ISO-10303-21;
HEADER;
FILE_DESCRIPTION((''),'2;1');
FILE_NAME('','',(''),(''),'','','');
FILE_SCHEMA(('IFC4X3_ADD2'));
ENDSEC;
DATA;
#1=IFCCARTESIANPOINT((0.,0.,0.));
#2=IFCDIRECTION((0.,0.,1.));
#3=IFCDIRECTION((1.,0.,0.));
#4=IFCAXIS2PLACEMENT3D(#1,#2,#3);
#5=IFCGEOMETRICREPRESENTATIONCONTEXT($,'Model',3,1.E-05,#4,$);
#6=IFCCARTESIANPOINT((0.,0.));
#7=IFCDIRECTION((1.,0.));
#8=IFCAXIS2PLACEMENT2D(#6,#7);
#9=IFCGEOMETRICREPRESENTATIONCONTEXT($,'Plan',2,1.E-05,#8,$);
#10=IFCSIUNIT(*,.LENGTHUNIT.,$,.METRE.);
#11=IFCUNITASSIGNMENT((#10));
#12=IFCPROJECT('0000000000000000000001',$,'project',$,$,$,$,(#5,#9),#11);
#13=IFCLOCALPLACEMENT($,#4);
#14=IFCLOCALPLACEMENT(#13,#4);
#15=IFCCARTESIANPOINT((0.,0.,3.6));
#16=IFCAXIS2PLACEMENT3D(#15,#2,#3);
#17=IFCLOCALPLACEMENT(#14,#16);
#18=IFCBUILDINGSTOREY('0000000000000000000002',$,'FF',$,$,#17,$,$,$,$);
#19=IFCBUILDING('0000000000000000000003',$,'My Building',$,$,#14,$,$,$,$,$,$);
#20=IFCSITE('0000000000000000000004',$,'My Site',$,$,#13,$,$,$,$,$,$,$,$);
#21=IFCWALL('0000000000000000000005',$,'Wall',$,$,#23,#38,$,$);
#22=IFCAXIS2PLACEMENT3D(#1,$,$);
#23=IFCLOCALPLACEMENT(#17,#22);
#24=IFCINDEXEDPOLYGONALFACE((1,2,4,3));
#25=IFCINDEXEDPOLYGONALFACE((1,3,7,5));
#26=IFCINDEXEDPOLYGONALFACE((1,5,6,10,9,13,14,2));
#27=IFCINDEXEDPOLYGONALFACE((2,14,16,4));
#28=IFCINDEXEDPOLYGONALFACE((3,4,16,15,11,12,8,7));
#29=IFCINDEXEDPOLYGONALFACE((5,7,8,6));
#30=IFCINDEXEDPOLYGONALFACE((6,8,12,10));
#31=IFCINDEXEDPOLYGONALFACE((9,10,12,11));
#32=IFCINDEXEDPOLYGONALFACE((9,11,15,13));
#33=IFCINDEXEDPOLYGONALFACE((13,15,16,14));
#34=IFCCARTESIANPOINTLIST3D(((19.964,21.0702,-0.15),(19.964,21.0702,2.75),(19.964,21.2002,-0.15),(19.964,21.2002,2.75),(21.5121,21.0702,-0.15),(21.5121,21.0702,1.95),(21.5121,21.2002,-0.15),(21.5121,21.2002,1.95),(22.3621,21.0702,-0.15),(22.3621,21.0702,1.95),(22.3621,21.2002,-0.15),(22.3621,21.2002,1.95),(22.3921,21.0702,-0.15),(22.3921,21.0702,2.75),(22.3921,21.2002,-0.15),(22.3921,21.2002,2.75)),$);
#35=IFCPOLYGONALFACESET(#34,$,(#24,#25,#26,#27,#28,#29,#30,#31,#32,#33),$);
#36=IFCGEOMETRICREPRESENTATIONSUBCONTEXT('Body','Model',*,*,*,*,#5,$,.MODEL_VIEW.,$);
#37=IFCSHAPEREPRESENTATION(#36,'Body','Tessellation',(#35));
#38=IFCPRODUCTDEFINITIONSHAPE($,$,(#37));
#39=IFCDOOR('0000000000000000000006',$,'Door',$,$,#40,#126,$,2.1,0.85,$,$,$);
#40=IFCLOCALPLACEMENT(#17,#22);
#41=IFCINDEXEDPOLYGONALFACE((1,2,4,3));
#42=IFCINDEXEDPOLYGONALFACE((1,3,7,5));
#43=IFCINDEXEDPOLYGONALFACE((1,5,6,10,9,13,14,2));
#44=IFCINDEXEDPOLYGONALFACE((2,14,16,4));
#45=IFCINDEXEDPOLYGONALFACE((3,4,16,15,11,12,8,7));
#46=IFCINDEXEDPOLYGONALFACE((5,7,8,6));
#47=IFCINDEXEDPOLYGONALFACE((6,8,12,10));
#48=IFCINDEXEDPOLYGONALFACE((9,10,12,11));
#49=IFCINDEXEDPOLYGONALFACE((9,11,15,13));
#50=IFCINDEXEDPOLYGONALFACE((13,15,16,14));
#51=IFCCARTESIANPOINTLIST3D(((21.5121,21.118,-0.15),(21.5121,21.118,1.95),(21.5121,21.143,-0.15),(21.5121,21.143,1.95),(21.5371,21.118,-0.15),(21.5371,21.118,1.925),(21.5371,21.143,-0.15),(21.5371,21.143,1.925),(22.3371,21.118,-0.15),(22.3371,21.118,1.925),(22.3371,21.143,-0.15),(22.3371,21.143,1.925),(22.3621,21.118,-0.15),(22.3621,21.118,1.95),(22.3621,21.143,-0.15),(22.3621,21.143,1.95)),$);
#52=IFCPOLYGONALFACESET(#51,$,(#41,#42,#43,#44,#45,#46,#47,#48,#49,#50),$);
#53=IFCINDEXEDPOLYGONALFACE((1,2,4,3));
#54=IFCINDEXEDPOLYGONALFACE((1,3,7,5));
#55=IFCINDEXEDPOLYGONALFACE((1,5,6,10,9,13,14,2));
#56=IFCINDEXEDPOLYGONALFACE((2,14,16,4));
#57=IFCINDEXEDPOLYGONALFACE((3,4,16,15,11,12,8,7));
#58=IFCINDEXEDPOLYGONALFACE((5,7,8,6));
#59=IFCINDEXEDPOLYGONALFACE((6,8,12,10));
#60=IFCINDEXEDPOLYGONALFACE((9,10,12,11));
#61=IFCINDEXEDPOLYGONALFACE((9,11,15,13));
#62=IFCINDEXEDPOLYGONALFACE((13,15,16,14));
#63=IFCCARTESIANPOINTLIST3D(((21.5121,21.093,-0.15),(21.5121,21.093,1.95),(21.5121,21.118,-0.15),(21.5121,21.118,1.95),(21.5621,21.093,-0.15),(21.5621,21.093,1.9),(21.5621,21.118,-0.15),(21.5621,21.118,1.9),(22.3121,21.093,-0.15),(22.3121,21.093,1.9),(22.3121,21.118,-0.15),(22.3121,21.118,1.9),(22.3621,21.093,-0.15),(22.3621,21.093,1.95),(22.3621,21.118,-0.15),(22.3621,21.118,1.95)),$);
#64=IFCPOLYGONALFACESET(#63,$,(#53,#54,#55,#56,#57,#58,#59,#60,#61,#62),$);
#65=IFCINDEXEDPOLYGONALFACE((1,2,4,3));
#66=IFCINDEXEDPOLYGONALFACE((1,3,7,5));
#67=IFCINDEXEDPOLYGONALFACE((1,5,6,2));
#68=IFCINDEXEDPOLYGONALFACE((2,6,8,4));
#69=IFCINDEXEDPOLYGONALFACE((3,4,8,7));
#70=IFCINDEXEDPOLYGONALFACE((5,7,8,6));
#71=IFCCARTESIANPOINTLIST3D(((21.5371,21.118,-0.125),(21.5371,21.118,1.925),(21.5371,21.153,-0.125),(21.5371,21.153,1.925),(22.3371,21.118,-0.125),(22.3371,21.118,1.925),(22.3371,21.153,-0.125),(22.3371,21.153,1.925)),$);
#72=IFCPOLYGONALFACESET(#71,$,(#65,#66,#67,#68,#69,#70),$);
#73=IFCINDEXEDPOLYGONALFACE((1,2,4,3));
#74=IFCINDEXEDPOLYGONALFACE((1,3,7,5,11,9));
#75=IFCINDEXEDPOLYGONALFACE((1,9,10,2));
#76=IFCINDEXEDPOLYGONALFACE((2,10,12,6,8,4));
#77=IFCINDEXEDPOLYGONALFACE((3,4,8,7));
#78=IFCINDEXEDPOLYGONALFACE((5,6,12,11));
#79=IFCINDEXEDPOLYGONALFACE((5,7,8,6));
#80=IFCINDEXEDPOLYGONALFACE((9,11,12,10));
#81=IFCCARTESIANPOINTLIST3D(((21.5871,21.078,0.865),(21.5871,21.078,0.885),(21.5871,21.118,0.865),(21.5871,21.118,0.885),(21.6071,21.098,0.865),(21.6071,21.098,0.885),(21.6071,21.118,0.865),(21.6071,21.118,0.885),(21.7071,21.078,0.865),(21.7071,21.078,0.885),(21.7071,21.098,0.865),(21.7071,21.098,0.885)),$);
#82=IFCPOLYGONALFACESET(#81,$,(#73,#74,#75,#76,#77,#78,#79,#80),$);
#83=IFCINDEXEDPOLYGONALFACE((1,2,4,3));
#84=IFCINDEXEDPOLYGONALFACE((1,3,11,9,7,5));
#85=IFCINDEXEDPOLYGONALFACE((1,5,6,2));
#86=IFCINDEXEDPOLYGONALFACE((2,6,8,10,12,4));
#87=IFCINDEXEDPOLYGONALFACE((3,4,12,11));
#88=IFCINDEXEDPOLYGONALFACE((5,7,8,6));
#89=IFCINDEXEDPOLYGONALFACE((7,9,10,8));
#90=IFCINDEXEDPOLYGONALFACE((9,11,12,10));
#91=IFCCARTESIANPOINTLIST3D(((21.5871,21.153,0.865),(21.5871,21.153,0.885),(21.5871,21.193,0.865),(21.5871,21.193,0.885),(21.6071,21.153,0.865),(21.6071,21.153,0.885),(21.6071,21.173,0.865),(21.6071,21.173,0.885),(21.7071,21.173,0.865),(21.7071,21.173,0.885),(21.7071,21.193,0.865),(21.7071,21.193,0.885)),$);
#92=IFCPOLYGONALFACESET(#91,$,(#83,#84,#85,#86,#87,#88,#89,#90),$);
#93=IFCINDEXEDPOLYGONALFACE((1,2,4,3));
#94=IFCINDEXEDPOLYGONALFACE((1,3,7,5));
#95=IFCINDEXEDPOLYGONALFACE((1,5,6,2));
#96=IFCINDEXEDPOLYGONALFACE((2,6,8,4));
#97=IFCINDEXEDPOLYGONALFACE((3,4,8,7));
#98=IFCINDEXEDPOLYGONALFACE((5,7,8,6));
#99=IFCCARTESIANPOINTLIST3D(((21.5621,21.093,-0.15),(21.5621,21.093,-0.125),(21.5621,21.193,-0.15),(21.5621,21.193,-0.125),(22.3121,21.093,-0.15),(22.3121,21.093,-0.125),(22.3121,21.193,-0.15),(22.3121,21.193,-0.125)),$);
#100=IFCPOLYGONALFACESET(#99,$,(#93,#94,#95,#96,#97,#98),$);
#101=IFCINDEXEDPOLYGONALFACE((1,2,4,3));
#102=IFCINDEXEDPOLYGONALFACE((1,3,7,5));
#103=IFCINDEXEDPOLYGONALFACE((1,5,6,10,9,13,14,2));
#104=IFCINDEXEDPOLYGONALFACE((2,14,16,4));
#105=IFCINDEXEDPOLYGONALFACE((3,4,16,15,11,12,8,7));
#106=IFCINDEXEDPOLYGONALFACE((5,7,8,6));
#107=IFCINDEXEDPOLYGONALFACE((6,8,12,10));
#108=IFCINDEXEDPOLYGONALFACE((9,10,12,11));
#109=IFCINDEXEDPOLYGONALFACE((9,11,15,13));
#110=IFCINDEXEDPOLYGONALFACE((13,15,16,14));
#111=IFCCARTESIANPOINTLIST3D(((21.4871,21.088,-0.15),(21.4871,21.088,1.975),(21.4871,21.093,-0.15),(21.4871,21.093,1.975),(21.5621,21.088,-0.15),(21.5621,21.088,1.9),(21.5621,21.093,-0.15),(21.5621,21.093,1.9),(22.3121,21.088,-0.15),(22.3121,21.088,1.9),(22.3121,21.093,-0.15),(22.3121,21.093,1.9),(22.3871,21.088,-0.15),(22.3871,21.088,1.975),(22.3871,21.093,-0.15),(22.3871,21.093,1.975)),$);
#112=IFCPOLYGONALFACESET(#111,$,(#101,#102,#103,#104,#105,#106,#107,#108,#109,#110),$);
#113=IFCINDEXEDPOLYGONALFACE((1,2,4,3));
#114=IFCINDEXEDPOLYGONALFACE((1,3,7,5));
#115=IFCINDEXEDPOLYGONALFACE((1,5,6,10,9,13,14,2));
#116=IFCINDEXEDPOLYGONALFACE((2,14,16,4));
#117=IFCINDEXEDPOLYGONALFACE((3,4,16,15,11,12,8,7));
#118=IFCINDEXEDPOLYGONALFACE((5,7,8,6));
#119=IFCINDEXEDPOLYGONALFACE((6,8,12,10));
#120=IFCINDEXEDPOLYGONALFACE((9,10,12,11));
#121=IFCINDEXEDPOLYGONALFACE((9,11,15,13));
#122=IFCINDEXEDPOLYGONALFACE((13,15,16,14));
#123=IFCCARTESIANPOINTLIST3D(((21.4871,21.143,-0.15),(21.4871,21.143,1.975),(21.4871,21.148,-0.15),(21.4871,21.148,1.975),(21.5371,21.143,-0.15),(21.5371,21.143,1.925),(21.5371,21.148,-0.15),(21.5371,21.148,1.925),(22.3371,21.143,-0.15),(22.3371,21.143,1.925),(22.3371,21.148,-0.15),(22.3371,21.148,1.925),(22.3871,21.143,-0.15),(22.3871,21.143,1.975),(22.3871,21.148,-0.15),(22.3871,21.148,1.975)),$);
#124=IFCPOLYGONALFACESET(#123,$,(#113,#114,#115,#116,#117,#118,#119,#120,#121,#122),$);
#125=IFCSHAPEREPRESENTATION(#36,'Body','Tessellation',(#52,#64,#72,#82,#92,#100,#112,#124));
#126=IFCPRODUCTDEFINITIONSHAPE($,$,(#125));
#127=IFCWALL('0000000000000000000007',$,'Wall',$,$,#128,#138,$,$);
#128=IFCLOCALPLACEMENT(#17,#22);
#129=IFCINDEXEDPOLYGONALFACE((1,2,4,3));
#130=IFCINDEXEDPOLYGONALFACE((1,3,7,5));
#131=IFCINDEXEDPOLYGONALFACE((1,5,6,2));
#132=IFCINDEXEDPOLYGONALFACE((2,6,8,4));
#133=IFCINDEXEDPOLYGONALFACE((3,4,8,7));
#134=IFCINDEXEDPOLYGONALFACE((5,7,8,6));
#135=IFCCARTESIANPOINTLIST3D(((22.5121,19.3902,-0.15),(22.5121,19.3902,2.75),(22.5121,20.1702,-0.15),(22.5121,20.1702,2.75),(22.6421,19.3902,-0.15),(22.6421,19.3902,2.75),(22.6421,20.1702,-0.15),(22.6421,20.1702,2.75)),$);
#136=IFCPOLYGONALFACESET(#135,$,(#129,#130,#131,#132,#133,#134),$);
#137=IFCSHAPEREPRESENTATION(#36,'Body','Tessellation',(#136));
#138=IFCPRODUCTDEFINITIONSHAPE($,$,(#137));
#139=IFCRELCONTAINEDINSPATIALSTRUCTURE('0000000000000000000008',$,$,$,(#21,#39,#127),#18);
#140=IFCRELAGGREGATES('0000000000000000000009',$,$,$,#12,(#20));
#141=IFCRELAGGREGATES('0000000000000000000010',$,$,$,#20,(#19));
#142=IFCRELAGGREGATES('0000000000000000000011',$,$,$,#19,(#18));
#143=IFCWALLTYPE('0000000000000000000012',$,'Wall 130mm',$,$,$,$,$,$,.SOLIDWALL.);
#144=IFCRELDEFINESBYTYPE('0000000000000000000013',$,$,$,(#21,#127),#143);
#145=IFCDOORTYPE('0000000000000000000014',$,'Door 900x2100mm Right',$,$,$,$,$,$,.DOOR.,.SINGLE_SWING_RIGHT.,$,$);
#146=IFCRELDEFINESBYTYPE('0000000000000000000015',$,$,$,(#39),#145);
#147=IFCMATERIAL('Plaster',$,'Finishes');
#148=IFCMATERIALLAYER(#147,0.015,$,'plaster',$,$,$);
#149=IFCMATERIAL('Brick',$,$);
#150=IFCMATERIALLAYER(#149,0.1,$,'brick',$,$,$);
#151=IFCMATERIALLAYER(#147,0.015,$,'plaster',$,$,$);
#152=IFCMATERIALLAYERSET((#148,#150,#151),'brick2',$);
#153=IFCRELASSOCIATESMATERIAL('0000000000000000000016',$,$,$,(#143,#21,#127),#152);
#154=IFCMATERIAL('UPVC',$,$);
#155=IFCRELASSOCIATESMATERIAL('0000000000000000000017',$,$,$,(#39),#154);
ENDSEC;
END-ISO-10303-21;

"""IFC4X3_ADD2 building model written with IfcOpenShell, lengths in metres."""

from ifc_helpers import new_model, entity, si_unit, frame, origin_with_axes, origin_2d_with_axis, place, context, subcontext, project, spatial, line, indexed_curve, outline, extrude, shape, source, transform, mapped, material, layer, layer_set, layer_usage, type_object, type_shapes, element, fill, save


model = new_model("IFC4X3_ADD2")

# Units and contexts
model_context = context("Model", 3, precision=1e-05, world=origin_with_axes())
plan_context = context("Plan", 2, precision=1e-05, world=origin_2d_with_axis())
body_context_1 = subcontext(model_context, "Body", "Model", "MODEL_VIEW")
body_context_2 = subcontext(plan_context, "Body", "Plan", "PLAN_VIEW")
ifc_project = project(units=[si_unit("LENGTHUNIT", "METRE")], contexts=[model_context, plan_context])

# Site, building, storey
site_placement = place(None, origin_with_axes())
site = spatial("IfcSite", under=ifc_project, at=site_placement, Name="My Site")
building_placement = place(site_placement, origin_with_axes())
building = spatial("IfcBuilding", under=site, at=building_placement, Name="My Building")
storey_placement = place(building_placement, frame((0.0, 0.0, 3.6), z_axis=(0.0, 0.0, 1.0), x_axis=(1.0, 0.0, 0.0)))
storey = spatial("IfcBuildingStorey", under=building, at=storey_placement, Name="FF")

# Shared definitions
ifc_material_1 = material(Name="UPVC")

# Shared definitions
ifc_material_2 = material(Name="Plaster", Category="Finishes")
ifc_material_3 = material(Name="Brick")

# Wall, opening, door
ifc_layer_1 = layer(ifc_material_2, 0.015, Name="plaster")
ifc_layer_2 = layer(ifc_material_3, 0.1, Name="brick")
ifc_layer_3 = layer(ifc_material_2, 0.015, Name="plaster")
ifc_layer_set_1 = layer_set([ifc_layer_1, ifc_layer_2, ifc_layer_3], Name="brick2")
ifc_layer_usage_1 = layer_usage(ifc_layer_set_1, "AXIS2", "POSITIVE", 0.0)
wall_type_1 = type_object("IfcWallType", Name="Wall 130mm", PredefinedType="SOLIDWALL", material=ifc_layer_set_1)
wall_1_placement = place(storey_placement, frame((22.6421, 21.2002, -0.15), z_axis=(0.0, 0.0, 1.0), x_axis=(-1.0, 0.0, 0.0)))
wall_1 = element("IfcWall", 1, at=wall_1_placement, inside=storey, type_object=wall_type_1, material=ifc_layer_usage_1, Name="Wall", context=body_context_1, shape_type="SweptSolid", body=[
    extrude(outline(indexed_curve([(0.25, 0.0), (0.25, 0.13), (2.6781, 0.13), (2.6781, 0.0)], segments=[line(1, 2, 3, 4, 1)])), origin_with_axes(), (0.0, 0.0, 1.0), 2.9),
])
shared_shape_1 = source(origin_with_axes(), body_context_1, "Body", "SweptSolid", [
    extrude(outline(indexed_curve([(0.0, 0.0), (0.85, 0.0), (0.85, 2.1), (0.0, 2.1)], segments=[line(1, 2, 3, 4, 1)])), frame((0.0, -0.6, 0.0), z_axis=(0.0, -1.0, 0.0), x_axis=(1.0, 0.0, 0.0)), (0.0, 0.0, -1.0), 1.2),
])
opening_placement = place(wall_1_placement, frame((1.13, 0.1072, 0.0), z_axis=(0.0, 0.0, 1.0), x_axis=(-1.0, 0.0, 0.0)))
opening = element("IfcOpeningElement", 2, at=opening_placement, cuts=wall_1, PredefinedType="OPENING", context=body_context_1, shape_type="MappedRepresentation", body=[
    mapped(shared_shape_1, transform((0.0, 0.0, 0.0), x_axis=(1.0, 0.0, 0.0), y_axis=(0.0, 1.0, 0.0), z_axis=(0.0, 0.0, 1.0), scale=1.0)),
])
door_type = type_object("IfcDoorType", Name="Door 900x2100mm Right", OperationType="SINGLE_SWING_RIGHT", PredefinedType="DOOR")
shared_shape_2 = source(origin_with_axes(), body_context_1, "Body", "SweptSolid", [
    extrude(outline(indexed_curve([(0.0, 0.0), (0.0, 2.1), (0.85, 2.1), (0.85, 0.0), (0.825, 0.0), (0.825, 2.075), (0.025, 2.075), (0.025, 0.0)], segments=[line(1, 2, 3, 4, 5, 6, 7, 8, 1)])), frame((0.0, 0.025, 0.0), z_axis=(0.0, -1.0, 0.0), x_axis=(1.0, 0.0, 0.0)), (0.0, 0.0, -1.0), 0.025),
    extrude(outline(indexed_curve([(0.0, 0.0), (0.0, 2.1), (0.85, 2.1), (0.85, 0.0), (0.8, 0.0), (0.8, 2.05), (0.05, 2.05), (0.05, 0.0)], segments=[line(1, 2, 3, 4, 5, 6, 7, 8, 1)])), frame((0.0, 0.0, 0.0), z_axis=(0.0, -1.0, 0.0), x_axis=(1.0, 0.0, 0.0)), (0.0, 0.0, -1.0), 0.025),
    extrude(outline(indexed_curve([(0.0, 0.0), (0.8, 0.0), (0.8, 0.035), (0.0, 0.035)], segments=[line(1, 2, 3, 4, 1)])), frame((0.025, 0.025, 0.025), z_axis=(0.0, 0.0, 1.0), x_axis=(1.0, 0.0, 0.0)), (0.0, 0.0, 1.0), 2.05),
    extrude(outline(indexed_curve([(0.0, 0.0), (0.0, -0.04), (0.12, -0.04), (0.12, -0.02), (0.02, -0.02), (0.02, 0.0)], segments=[line(1, 2, 3, 4, 5, 6, 1)])), frame((0.075, 0.025, 1.015), z_axis=(0.0, 0.0, 1.0), x_axis=(1.0, 0.0, 0.0)), (0.0, 0.0, 1.0), 0.02),
    extrude(outline(indexed_curve([(0.0, 0.0), (0.0, 0.04), (0.12, 0.04), (0.12, 0.02), (0.02, 0.02), (0.02, 0.0)], segments=[line(1, 2, 3, 4, 5, 6, 1)])), frame((0.075, 0.06, 1.015), z_axis=(0.0, 0.0, 1.0), x_axis=(1.0, 0.0, 0.0)), (0.0, 0.0, 1.0), 0.02),
    extrude(outline(indexed_curve([(0.0, 0.0), (0.75, 0.0), (0.75, 0.1), (0.0, 0.1)], segments=[line(1, 2, 3, 4, 1)])), frame((0.05, 0.0, 0.0), z_axis=(0.0, 0.0, 1.0), x_axis=(1.0, 0.0, 0.0)), (0.0, 0.0, 1.0), 0.025),
    extrude(outline(indexed_curve([(0.0, 0.0), (0.0, 2.125), (0.9, 2.125), (0.9, 0.0), (0.825, 0.0), (0.825, 2.05), (0.075, 2.05), (0.075, 0.0)], segments=[line(1, 2, 3, 4, 5, 6, 7, 8, 1)])), frame((-0.025, -0.005, 0.0), z_axis=(0.0, -1.0, 0.0), x_axis=(1.0, 0.0, 0.0)), (0.0, 0.0, -1.0), 0.005),
    extrude(outline(indexed_curve([(0.0, 0.0), (0.0, 2.125), (0.9, 2.125), (0.9, 0.0), (0.85, 0.0), (0.85, 2.075), (0.05, 2.075), (0.05, 0.0)], segments=[line(1, 2, 3, 4, 5, 6, 7, 8, 1)])), frame((-0.025, 0.05, 0.0), z_axis=(0.0, -1.0, 0.0), x_axis=(1.0, 0.0, 0.0)), (0.0, 0.0, -1.0), 0.005),
])
shared_shape_3 = source(origin_with_axes(), body_context_2, "Body", "Curve2D", [
    entity("IfcIndexedPolyCurve", entity("IfcCartesianPointList2D", [[0.0, 0.0], [0.0, 0.05], [0.025, 0.05], [0.025, 0.025], [0.05, 0.025], [0.05, 0.0]]), [entity("IfcLineIndex", [1, 2, 3, 4, 5, 6, 1])]),
    entity("IfcIndexedPolyCurve", entity("IfcCartesianPointList2D", [[0.85, 0.0], [0.85, 0.05], [0.825, 0.05], [0.825, 0.025], [0.8, 0.025], [0.8, 0.0]]), [entity("IfcLineIndex", [1, 2, 3, 4, 5, 6, 1])]),
    entity("IfcTrimmedCurve", entity("IfcEllipse", entity("IfcAxis2Placement2D", entity("IfcCartesianPoint", [0.79, 0.05]), entity("IfcDirection", [1.0, 0.0])), 0.765, 0.8), [entity("IfcCartesianPoint", [0.79, 0.85])], [entity("IfcCartesianPoint", [0.025, 0.05])], True, "CARTESIAN"),
    entity("IfcIndexedPolyCurve", entity("IfcCartesianPointList2D", [[0.825, 0.05], [0.79, 0.05], [0.79, 0.85], [0.825, 0.85]]), [entity("IfcLineIndex", [1, 2, 3, 4, 1])]),
])
type_shapes(door_type, [shared_shape_2, shared_shape_3])
door_placement = place(opening_placement, frame((0.0, 0.0, 0.0), z_axis=(0.0, 0.0, 1.0), x_axis=(1.0, 0.0, 0.0)))
door = element("IfcDoor", 3, at=door_placement, inside=storey, type_object=door_type, material=ifc_material_1, Name="Door", OverallHeight=2.1, OverallWidth=0.85, shapes=[
    shape(body_context_1, "Body", "MappedRepresentation", [mapped(shared_shape_2, transform((0.0, 0.0, 0.0), x_axis=(1.0, 0.0, 0.0), y_axis=(0.0, 1.0, 0.0), z_axis=(0.0, 0.0, 1.0), scale=1.0))]),
    shape(body_context_2, "Body", "MappedRepresentation", [mapped(shared_shape_3, transform((0.0, 0.0, 0.0), x_axis=(1.0, 0.0, 0.0), y_axis=(0.0, 1.0, 0.0), z_axis=(0.0, 0.0, 1.0), scale=1.0))]),
])
fill(opening, door)

# Wall
ifc_layer_usage_2 = layer_usage(ifc_layer_set_1, "AXIS2", "POSITIVE", 0.0)
wall_2_placement = place(storey_placement, frame((22.6421, 19.3902, -0.15), z_axis=(0.0, 0.0, 1.0), x_axis=(0.000001, 1.0, 0.0)))
element("IfcWall", 4, at=wall_2_placement, inside=storey, type_object=wall_type_1, material=ifc_layer_usage_2, Name="Wall", context=body_context_1, shape_type="SweptSolid", body=[
    extrude(outline(indexed_curve([(0.0, 0.0), (0.0, 0.13), (0.78, 0.13), (0.78, 0.0)], segments=[line(1, 2, 3, 4, 1)])), origin_with_axes(), (0.0, 0.0, 1.0), 2.9),
])

save(model, "model.ifc")
